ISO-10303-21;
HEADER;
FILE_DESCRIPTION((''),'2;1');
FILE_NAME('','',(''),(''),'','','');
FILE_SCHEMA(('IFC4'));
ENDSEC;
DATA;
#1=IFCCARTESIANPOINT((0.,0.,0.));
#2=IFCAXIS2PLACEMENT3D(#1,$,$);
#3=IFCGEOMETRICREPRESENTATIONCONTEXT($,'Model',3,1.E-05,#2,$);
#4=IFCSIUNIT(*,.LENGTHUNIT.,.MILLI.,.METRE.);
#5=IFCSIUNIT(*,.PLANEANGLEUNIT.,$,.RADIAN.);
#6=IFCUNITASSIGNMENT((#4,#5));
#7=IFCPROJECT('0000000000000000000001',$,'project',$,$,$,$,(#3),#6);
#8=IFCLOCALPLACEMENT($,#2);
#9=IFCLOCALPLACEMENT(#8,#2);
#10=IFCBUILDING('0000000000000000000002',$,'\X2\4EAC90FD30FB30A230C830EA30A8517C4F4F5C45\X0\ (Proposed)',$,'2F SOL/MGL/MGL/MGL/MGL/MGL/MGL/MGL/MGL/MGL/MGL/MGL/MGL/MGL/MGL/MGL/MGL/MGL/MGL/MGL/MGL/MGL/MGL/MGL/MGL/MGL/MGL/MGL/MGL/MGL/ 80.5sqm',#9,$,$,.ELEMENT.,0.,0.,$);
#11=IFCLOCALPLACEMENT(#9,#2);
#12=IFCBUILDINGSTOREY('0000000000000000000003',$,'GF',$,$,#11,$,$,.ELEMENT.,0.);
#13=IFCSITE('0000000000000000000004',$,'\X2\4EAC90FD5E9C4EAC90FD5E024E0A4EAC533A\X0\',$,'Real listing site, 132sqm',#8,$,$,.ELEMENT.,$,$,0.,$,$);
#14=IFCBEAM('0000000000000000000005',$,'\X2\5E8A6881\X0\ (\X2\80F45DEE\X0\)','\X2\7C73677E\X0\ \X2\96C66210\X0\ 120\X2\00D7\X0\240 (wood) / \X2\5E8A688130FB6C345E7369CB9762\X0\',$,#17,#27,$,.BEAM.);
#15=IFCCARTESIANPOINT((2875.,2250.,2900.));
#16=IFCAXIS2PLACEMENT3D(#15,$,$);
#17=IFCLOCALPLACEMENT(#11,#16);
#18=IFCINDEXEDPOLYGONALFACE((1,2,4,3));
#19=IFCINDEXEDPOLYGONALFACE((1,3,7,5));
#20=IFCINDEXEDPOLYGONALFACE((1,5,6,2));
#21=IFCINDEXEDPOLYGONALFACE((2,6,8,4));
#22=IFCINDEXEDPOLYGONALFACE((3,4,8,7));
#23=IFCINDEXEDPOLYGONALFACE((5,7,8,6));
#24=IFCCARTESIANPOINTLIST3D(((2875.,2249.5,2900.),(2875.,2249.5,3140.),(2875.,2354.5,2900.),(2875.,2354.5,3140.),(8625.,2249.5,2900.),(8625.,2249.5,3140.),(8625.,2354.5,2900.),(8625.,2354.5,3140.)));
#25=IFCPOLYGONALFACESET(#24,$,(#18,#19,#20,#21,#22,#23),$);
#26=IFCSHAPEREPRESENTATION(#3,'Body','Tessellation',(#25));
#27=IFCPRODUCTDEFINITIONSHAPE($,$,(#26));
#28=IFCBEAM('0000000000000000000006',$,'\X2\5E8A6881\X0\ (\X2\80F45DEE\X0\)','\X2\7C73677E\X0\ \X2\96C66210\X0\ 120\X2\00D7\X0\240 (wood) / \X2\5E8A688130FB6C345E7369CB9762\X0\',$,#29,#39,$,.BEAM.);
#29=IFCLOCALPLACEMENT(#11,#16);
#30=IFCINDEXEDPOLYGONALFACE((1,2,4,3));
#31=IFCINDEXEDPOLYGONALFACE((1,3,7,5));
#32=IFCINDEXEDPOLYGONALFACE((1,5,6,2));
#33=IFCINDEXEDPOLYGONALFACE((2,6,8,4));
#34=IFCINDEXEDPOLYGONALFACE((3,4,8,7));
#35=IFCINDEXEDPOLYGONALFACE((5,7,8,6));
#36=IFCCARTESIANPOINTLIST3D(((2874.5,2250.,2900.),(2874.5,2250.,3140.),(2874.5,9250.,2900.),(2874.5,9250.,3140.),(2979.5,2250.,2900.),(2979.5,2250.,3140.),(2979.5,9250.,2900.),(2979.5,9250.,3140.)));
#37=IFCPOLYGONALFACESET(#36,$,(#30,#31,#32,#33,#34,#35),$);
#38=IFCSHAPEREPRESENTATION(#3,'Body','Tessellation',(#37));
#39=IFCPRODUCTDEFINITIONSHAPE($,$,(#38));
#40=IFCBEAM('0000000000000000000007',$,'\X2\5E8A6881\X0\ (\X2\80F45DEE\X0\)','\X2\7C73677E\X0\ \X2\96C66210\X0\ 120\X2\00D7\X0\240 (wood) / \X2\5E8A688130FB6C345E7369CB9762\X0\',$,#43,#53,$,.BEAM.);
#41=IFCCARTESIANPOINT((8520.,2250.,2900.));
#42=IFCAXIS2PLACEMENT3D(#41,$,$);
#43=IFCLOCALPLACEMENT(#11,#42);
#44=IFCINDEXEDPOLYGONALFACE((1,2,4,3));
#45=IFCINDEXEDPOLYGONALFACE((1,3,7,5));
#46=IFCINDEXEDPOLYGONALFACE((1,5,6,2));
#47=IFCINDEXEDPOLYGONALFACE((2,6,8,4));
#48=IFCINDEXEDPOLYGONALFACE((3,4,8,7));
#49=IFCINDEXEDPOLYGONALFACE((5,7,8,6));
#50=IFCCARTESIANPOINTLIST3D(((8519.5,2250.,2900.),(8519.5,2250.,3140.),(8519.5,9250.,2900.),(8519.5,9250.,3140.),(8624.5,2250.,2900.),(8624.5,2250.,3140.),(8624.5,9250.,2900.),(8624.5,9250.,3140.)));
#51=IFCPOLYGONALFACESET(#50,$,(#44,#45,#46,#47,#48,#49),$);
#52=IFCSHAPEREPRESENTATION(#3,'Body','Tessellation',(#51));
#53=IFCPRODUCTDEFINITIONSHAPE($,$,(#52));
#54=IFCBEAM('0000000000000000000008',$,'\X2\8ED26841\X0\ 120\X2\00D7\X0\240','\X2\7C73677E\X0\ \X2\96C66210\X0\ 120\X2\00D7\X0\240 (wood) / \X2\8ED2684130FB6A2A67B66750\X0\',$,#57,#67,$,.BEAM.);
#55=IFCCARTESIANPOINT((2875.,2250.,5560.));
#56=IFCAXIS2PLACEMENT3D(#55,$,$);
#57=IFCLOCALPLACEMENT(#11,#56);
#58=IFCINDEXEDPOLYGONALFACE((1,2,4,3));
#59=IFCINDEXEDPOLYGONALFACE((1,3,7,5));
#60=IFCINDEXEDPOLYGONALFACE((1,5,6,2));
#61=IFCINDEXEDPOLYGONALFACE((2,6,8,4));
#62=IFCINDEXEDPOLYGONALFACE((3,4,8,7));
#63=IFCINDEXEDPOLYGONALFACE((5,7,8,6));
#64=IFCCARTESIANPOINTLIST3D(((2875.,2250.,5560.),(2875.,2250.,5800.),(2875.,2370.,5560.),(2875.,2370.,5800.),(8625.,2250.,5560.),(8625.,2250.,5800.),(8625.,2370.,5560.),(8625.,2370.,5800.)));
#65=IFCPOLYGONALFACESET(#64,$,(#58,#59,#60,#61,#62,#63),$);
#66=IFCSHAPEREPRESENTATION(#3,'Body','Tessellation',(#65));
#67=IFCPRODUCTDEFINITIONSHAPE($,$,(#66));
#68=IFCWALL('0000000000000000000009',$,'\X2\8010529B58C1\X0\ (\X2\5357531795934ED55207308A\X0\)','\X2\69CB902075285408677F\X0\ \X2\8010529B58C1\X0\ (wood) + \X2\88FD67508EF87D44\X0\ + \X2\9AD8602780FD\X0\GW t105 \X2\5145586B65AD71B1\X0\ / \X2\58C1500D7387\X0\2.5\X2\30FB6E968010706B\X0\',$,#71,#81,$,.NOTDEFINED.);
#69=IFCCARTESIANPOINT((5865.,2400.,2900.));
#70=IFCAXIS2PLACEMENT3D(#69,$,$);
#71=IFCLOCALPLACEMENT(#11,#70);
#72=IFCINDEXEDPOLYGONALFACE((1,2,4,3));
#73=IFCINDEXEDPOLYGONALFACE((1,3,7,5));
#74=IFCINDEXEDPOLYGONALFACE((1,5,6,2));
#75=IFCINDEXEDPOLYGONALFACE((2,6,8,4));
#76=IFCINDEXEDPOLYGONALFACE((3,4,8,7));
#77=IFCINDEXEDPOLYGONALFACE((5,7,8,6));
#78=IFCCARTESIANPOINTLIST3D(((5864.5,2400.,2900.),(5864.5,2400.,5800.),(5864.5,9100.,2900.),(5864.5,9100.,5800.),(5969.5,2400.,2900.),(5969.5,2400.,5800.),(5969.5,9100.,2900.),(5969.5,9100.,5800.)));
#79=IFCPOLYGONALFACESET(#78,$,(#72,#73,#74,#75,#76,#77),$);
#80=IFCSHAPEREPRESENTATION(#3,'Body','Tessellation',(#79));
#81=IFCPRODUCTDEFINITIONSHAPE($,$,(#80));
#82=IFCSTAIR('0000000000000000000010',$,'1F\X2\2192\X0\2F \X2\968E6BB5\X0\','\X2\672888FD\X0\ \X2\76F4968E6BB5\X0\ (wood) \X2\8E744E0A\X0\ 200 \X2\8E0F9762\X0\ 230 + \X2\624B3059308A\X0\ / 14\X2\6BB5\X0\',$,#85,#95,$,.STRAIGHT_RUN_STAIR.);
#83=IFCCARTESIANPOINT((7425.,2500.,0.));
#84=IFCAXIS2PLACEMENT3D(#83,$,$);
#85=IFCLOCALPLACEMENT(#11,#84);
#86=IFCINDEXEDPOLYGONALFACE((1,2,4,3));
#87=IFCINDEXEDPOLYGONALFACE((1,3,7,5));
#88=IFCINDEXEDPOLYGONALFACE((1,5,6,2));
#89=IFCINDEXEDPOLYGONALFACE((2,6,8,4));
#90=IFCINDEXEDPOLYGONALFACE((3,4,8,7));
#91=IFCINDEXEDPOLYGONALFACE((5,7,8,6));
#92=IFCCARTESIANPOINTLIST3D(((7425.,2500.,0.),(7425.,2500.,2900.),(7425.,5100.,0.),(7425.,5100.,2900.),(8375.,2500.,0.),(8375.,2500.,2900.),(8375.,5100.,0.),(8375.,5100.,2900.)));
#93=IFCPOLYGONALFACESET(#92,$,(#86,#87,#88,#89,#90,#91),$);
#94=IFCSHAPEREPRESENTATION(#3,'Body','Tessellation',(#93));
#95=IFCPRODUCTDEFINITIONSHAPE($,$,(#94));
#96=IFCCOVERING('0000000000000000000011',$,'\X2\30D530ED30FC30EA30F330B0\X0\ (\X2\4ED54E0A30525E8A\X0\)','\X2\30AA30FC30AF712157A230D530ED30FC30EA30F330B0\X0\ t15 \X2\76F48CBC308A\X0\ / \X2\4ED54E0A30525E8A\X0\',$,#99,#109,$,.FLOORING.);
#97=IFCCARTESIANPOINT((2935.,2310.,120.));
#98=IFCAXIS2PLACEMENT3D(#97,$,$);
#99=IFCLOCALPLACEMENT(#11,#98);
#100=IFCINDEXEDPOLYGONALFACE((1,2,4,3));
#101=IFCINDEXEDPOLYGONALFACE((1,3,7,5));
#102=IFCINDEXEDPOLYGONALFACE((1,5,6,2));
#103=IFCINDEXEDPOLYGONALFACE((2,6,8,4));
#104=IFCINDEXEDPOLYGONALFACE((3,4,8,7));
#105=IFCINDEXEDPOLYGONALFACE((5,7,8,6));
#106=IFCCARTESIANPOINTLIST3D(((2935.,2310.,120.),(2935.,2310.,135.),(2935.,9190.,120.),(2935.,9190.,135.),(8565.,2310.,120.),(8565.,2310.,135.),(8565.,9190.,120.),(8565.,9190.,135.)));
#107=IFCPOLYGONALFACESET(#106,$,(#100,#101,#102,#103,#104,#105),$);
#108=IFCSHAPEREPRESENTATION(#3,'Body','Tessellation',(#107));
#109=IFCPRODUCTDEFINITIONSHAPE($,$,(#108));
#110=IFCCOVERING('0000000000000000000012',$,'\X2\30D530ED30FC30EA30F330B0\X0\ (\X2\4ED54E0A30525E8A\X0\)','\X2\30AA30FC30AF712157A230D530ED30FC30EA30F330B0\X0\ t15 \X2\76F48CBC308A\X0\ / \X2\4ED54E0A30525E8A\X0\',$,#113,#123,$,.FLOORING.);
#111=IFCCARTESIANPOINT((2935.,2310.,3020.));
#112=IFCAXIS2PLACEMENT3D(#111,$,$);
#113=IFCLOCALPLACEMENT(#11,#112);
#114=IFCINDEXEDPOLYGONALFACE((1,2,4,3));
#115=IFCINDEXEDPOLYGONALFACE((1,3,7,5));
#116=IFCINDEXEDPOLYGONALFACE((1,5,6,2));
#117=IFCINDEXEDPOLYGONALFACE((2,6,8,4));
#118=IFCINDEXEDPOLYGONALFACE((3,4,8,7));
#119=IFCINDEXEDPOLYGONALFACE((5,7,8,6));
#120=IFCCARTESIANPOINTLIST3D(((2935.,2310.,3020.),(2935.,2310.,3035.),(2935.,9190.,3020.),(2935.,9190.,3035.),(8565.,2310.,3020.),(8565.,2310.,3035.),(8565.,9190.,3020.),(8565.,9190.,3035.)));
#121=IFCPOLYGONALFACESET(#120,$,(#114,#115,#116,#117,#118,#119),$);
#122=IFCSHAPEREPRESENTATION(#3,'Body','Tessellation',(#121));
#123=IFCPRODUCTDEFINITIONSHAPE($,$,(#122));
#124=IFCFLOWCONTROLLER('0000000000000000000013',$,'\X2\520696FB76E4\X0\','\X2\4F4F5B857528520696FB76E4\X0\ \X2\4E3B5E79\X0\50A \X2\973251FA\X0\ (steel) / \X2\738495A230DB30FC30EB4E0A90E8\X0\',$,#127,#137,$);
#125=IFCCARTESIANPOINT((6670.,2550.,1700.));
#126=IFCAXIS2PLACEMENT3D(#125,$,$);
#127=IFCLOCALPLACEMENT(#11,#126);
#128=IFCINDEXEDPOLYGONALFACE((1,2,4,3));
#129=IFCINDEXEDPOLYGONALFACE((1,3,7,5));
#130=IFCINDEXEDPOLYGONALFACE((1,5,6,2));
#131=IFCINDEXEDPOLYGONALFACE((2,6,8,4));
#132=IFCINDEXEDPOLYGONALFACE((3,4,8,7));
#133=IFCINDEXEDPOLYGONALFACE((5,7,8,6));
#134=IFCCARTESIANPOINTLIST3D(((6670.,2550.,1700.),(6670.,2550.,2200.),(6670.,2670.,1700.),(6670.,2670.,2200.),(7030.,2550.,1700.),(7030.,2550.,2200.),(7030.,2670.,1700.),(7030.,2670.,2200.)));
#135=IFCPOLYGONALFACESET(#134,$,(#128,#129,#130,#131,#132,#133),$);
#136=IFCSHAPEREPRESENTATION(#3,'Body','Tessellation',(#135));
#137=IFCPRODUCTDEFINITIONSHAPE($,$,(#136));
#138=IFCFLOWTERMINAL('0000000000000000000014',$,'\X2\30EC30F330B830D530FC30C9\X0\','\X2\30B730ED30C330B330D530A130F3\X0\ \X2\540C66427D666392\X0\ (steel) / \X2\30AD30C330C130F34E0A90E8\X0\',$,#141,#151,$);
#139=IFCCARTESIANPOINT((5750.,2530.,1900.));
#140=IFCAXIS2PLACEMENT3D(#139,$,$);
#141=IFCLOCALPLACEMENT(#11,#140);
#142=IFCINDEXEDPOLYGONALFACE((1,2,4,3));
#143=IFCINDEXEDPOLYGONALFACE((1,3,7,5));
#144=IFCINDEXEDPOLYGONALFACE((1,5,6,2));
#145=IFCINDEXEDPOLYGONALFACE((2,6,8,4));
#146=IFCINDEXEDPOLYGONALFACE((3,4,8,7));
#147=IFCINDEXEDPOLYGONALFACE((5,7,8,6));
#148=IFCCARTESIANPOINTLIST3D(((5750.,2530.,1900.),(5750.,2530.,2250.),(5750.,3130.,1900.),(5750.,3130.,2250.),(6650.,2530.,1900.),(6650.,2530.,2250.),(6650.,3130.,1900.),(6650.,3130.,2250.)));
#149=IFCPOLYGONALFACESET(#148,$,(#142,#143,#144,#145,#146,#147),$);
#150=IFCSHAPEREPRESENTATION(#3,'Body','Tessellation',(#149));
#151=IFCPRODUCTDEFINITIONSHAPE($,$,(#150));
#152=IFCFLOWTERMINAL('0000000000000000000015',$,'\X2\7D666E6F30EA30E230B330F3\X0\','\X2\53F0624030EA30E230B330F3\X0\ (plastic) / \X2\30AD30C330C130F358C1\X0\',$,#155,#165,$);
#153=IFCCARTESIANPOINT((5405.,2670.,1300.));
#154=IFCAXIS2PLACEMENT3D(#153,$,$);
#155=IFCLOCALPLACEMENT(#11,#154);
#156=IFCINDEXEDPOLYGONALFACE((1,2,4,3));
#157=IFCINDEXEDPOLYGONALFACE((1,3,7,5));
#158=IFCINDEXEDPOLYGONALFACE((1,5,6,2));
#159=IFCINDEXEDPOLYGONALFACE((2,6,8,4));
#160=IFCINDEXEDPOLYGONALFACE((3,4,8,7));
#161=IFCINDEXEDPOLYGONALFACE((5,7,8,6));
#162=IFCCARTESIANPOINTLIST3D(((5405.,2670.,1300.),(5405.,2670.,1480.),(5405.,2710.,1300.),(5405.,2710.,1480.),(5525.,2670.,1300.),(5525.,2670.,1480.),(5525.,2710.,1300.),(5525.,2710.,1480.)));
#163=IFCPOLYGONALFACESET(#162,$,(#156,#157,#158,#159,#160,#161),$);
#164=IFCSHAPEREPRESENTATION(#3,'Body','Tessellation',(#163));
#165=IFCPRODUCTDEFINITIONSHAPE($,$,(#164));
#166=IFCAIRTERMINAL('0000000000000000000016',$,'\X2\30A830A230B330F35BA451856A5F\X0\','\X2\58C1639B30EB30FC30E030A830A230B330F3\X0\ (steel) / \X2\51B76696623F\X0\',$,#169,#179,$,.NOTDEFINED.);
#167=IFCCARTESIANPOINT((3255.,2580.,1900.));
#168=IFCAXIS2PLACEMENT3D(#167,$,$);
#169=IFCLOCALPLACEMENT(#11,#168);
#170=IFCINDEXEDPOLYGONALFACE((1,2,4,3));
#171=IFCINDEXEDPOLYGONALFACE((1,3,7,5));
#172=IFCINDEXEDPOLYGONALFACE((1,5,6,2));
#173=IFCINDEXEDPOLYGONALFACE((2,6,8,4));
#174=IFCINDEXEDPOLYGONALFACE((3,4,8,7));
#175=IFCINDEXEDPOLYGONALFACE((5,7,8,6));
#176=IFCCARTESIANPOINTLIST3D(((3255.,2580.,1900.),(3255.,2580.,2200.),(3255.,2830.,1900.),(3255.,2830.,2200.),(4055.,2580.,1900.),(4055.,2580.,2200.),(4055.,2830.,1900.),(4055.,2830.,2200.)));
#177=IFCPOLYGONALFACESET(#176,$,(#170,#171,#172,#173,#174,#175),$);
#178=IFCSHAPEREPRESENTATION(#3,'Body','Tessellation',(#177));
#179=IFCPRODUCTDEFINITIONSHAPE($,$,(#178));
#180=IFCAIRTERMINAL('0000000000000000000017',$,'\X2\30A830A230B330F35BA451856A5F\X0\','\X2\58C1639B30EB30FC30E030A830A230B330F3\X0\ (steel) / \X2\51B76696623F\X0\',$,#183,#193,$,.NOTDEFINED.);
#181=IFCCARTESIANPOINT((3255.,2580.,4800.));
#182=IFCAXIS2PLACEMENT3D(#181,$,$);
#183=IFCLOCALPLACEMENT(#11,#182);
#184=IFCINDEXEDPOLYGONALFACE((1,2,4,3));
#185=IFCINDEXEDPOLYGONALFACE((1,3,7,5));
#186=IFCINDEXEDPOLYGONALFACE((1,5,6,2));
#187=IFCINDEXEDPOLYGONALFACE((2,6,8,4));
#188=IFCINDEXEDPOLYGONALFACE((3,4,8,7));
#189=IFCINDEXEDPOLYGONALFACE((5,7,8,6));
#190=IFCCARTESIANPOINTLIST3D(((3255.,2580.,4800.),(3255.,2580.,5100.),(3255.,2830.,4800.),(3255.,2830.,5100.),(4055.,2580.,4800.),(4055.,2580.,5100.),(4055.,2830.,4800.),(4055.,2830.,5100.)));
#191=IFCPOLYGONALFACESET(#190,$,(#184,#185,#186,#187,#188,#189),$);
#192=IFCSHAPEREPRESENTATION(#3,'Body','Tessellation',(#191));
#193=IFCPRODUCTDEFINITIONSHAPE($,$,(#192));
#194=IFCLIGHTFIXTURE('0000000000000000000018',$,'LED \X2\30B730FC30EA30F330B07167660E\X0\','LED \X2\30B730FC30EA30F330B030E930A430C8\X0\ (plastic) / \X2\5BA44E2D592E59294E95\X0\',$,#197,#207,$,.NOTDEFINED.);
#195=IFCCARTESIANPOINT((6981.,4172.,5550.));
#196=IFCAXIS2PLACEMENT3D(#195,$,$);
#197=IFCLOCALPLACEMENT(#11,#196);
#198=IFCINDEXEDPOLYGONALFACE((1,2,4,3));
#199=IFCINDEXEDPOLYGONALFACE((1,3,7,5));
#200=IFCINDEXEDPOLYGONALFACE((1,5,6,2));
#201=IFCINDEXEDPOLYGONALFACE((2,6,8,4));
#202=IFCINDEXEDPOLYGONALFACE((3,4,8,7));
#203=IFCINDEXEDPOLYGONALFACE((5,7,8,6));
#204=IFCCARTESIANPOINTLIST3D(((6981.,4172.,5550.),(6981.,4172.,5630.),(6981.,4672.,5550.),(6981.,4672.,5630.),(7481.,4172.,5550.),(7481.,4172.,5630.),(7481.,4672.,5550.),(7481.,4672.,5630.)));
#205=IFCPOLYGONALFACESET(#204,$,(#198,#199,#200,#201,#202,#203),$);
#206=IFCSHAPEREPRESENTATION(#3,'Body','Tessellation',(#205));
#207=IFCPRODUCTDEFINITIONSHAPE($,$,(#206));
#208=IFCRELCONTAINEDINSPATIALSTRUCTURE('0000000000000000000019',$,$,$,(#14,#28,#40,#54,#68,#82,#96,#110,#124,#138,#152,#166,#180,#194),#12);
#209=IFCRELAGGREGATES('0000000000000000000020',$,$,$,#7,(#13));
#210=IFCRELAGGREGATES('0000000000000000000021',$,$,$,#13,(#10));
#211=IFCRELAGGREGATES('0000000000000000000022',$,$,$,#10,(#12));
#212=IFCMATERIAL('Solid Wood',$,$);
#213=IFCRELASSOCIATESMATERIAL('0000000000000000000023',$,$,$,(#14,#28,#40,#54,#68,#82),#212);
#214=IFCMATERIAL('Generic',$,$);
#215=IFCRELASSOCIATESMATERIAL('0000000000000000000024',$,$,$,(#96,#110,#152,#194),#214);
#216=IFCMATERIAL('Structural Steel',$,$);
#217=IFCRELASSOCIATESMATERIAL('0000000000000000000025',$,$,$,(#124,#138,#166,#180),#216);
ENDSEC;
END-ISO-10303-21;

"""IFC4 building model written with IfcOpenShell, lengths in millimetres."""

from ifc_helpers import new_model, si_unit, frame, frame_2d, origin, place, context, project, spatial, rectangle, extrude, material, element, save


model = new_model("IFC4")

# Units and contexts
model_context = context("Model", 3, precision=1e-05, world=origin())
ifc_project = project(units=[si_unit("LENGTHUNIT", "METRE", prefix="MILLI"), si_unit("PLANEANGLEUNIT", "RADIAN")], contexts=[model_context])

# Site, building, storey
site_placement = place(None, origin())
site = spatial("IfcSite", under=ifc_project, at=site_placement, Name="京都府京都市上京区", ObjectType="Real listing site, 132sqm", CompositionType="ELEMENT", RefElevation=0.0)
building_placement = place(site_placement, origin())
building = spatial("IfcBuilding", under=site, at=building_placement, Name="京都・アトリエ兼住居 (Proposed)", ObjectType="2F SOL/MGL/MGL/MGL/MGL/MGL/MGL/MGL/MGL/MGL/MGL/MGL/MGL/MGL/MGL/MGL/MGL/MGL/MGL/MGL/MGL/MGL/MGL/MGL/MGL/MGL/MGL/MGL/MGL/MGL/ 80.5sqm", CompositionType="ELEMENT", ElevationOfRefHeight=0.0, ElevationOfTerrain=0.0)
storey_placement = place(building_placement, origin())
storey = spatial("IfcBuildingStorey", under=building, at=storey_placement, Name="GF", CompositionType="ELEMENT", Elevation=0.0)

# Shared definitions
ifc_material_1 = material(Name="Solid Wood")

# Beams
beam_1_placement = place(storey_placement, frame((2875.0, 2250.0, 2900.0)))
element("IfcBeam", 1, at=beam_1_placement, inside=storey, material=ifc_material_1, Name="床梁 (胴差)", Description="米松 集成 120×240 (wood) / 床梁・水平構面", PredefinedType="BEAM", context=model_context, shape_type="SweptSolid", body=[
    extrude(rectangle(XDim=5750.0, YDim=105.0, at=frame_2d((2875.0, 52.0))), frame((2875.0, 2250.0, 2900.0)), (0.0, 0.0, 1.0), 240.0),
])
beam_2_placement = place(storey_placement, frame((2875.0, 2250.0, 2900.0)))
element("IfcBeam", 2, at=beam_2_placement, inside=storey, material=ifc_material_1, Name="床梁 (胴差)", Description="米松 集成 120×240 (wood) / 床梁・水平構面", PredefinedType="BEAM", context=model_context, shape_type="SweptSolid", body=[
    extrude(rectangle(XDim=105.0, YDim=7000.0, at=frame_2d((52.0, 3500.0))), frame((2875.0, 2250.0, 2900.0)), (0.0, 0.0, 1.0), 240.0),
])
beam_3_placement = place(storey_placement, frame((8520.0, 2250.0, 2900.0)))
element("IfcBeam", 3, at=beam_3_placement, inside=storey, material=ifc_material_1, Name="床梁 (胴差)", Description="米松 集成 120×240 (wood) / 床梁・水平構面", PredefinedType="BEAM", context=model_context, shape_type="SweptSolid", body=[
    extrude(rectangle(XDim=105.0, YDim=7000.0, at=frame_2d((52.0, 3500.0))), frame((8520.0, 2250.0, 2900.0)), (0.0, 0.0, 1.0), 240.0),
])
beam_4_placement = place(storey_placement, frame((2875.0, 2250.0, 5560.0)))
element("IfcBeam", 4, at=beam_4_placement, inside=storey, material=ifc_material_1, Name="軒桁 120×240", Description="米松 集成 120×240 (wood) / 軒桁・横架材", PredefinedType="BEAM", context=model_context, shape_type="SweptSolid", body=[
    extrude(rectangle(XDim=5750.0, YDim=120.0, at=frame_2d((2875.0, 60.0))), frame((2875.0, 2250.0, 5560.0)), (0.0, 0.0, 1.0), 240.0),
])

# Wall
wall_1_placement = place(storey_placement, frame((5865.0, 2400.0, 2900.0)))
element("IfcWall", 5, at=wall_1_placement, inside=storey, material=ifc_material_1, Name="耐力壁 (南北間仕切り)", Description="構造用合板 耐力壁 (wood) + 製材軸組 + 高性能GW t105 充填断熱 / 壁倍率2.5・準耐火", PredefinedType="NOTDEFINED", context=model_context, shape_type="SweptSolid", body=[
    extrude(rectangle(XDim=105.0, YDim=6700.0, at=frame_2d((52.0, 3350.0))), frame((5865.0, 2400.0, 2900.0)), (0.0, 0.0, 1.0), 2900.0),
])

# Stair
stair_placement = place(storey_placement, frame((7425.0, 2500.0, 0.0)))
element("IfcStair", 6, at=stair_placement, inside=storey, material=ifc_material_1, Name="1F→2F 階段", Description="木製 直階段 (wood) 蹴上 200 踏面 230 + 手すり / 14段", PredefinedType="STRAIGHT_RUN_STAIR", context=model_context, shape_type="SweptSolid", body=[
    extrude(rectangle(XDim=950.0, YDim=2600.0, at=frame_2d((475.0, 1300.0))), frame((7425.0, 2500.0, 0.0)), (0.0, 0.0, 1.0), 2900.0),
])

# Coverings
ifc_material_2 = material(Name="Generic")
covering_1_placement = place(storey_placement, frame((2935.0, 2310.0, 120.0)))
element("IfcCovering", 7, at=covering_1_placement, inside=storey, material=ifc_material_2, Name="フローリング (仕上げ床)", Description="オーク無垢フローリング t15 直貼り / 仕上げ床", PredefinedType="FLOORING", context=model_context, shape_type="SweptSolid", body=[
    extrude(rectangle(XDim=5630.0, YDim=6880.0, at=frame_2d((2815.0, 3440.0))), frame((2935.0, 2310.0, 120.0)), (0.0, 0.0, 1.0), 15.0),
])
covering_2_placement = place(storey_placement, frame((2935.0, 2310.0, 3020.0)))
element("IfcCovering", 8, at=covering_2_placement, inside=storey, material=ifc_material_2, Name="フローリング (仕上げ床)", Description="オーク無垢フローリング t15 直貼り / 仕上げ床", PredefinedType="FLOORING", context=model_context, shape_type="SweptSolid", body=[
    extrude(rectangle(XDim=5630.0, YDim=6880.0, at=frame_2d((2815.0, 3440.0))), frame((2935.0, 2310.0, 3020.0)), (0.0, 0.0, 1.0), 15.0),
])

# Flow controller
ifc_material_3 = material(Name="Structural Steel")
flow_controller_placement = place(storey_placement, frame((6670.0, 2550.0, 1700.0)))
element("IfcFlowController", 9, at=flow_controller_placement, inside=storey, material=ifc_material_3, Name="分電盤", Description="住宅用分電盤 主幹50A 露出 (steel) / 玄関ホール上部", context=model_context, shape_type="SweptSolid", body=[
    extrude(rectangle(XDim=360.0, YDim=120.0, at=frame_2d((180.0, 60.0))), frame((6670.0, 2550.0, 1700.0)), (0.0, 0.0, 1.0), 500.0),
])

# Flow terminals
flow_terminal_1_placement = place(storey_placement, frame((5750.0, 2530.0, 1900.0)))
element("IfcFlowTerminal", 10, at=flow_terminal_1_placement, inside=storey, material=ifc_material_3, Name="レンジフード", Description="シロッコファン 同時給排 (steel) / キッチン上部", context=model_context, shape_type="SweptSolid", body=[
    extrude(rectangle(XDim=900.0, YDim=600.0, at=frame_2d((450.0, 300.0))), frame((5750.0, 2530.0, 1900.0)), (0.0, 0.0, 1.0), 350.0),
])
flow_terminal_2_placement = place(storey_placement, frame((5405.0, 2670.0, 1300.0)))
element("IfcFlowTerminal", 11, at=flow_terminal_2_placement, inside=storey, material=ifc_material_2, Name="給湯リモコン", Description="台所リモコン (plastic) / キッチン壁", context=model_context, shape_type="SweptSolid", body=[
    extrude(rectangle(XDim=120.0, YDim=40.0, at=frame_2d((60.0, 20.0))), frame((5405.0, 2670.0, 1300.0)), (0.0, 0.0, 1.0), 180.0),
])

# Air terminals
air_terminal_1_placement = place(storey_placement, frame((3255.0, 2580.0, 1900.0)))
element("IfcAirTerminal", 12, at=air_terminal_1_placement, inside=storey, material=ifc_material_3, Name="エアコン室内機", Description="壁掛ルームエアコン (steel) / 冷暖房", PredefinedType="NOTDEFINED", context=model_context, shape_type="SweptSolid", body=[
    extrude(rectangle(XDim=800.0, YDim=250.0, at=frame_2d((400.0, 125.0))), frame((3255.0, 2580.0, 1900.0)), (0.0, 0.0, 1.0), 300.0),
])
air_terminal_2_placement = place(storey_placement, frame((3255.0, 2580.0, 4800.0)))
element("IfcAirTerminal", 13, at=air_terminal_2_placement, inside=storey, material=ifc_material_3, Name="エアコン室内機", Description="壁掛ルームエアコン (steel) / 冷暖房", PredefinedType="NOTDEFINED", context=model_context, shape_type="SweptSolid", body=[
    extrude(rectangle(XDim=800.0, YDim=250.0, at=frame_2d((400.0, 125.0))), frame((3255.0, 2580.0, 4800.0)), (0.0, 0.0, 1.0), 300.0),
])

# Light fixture
light_fixture_placement = place(storey_placement, frame((6981.0, 4172.0, 5550.0)))
element("IfcLightFixture", 14, at=light_fixture_placement, inside=storey, material=ifc_material_2, Name="LED シーリング照明", Description="LED シーリングライト (plastic) / 室中央天井", PredefinedType="NOTDEFINED", context=model_context, shape_type="SweptSolid", body=[
    extrude(rectangle(XDim=500.0, YDim=500.0, at=frame_2d((250.0, 250.0))), frame((6981.0, 4172.0, 5550.0)), (0.0, 0.0, 1.0), 80.0),
])

save(model, "model.ifc")
